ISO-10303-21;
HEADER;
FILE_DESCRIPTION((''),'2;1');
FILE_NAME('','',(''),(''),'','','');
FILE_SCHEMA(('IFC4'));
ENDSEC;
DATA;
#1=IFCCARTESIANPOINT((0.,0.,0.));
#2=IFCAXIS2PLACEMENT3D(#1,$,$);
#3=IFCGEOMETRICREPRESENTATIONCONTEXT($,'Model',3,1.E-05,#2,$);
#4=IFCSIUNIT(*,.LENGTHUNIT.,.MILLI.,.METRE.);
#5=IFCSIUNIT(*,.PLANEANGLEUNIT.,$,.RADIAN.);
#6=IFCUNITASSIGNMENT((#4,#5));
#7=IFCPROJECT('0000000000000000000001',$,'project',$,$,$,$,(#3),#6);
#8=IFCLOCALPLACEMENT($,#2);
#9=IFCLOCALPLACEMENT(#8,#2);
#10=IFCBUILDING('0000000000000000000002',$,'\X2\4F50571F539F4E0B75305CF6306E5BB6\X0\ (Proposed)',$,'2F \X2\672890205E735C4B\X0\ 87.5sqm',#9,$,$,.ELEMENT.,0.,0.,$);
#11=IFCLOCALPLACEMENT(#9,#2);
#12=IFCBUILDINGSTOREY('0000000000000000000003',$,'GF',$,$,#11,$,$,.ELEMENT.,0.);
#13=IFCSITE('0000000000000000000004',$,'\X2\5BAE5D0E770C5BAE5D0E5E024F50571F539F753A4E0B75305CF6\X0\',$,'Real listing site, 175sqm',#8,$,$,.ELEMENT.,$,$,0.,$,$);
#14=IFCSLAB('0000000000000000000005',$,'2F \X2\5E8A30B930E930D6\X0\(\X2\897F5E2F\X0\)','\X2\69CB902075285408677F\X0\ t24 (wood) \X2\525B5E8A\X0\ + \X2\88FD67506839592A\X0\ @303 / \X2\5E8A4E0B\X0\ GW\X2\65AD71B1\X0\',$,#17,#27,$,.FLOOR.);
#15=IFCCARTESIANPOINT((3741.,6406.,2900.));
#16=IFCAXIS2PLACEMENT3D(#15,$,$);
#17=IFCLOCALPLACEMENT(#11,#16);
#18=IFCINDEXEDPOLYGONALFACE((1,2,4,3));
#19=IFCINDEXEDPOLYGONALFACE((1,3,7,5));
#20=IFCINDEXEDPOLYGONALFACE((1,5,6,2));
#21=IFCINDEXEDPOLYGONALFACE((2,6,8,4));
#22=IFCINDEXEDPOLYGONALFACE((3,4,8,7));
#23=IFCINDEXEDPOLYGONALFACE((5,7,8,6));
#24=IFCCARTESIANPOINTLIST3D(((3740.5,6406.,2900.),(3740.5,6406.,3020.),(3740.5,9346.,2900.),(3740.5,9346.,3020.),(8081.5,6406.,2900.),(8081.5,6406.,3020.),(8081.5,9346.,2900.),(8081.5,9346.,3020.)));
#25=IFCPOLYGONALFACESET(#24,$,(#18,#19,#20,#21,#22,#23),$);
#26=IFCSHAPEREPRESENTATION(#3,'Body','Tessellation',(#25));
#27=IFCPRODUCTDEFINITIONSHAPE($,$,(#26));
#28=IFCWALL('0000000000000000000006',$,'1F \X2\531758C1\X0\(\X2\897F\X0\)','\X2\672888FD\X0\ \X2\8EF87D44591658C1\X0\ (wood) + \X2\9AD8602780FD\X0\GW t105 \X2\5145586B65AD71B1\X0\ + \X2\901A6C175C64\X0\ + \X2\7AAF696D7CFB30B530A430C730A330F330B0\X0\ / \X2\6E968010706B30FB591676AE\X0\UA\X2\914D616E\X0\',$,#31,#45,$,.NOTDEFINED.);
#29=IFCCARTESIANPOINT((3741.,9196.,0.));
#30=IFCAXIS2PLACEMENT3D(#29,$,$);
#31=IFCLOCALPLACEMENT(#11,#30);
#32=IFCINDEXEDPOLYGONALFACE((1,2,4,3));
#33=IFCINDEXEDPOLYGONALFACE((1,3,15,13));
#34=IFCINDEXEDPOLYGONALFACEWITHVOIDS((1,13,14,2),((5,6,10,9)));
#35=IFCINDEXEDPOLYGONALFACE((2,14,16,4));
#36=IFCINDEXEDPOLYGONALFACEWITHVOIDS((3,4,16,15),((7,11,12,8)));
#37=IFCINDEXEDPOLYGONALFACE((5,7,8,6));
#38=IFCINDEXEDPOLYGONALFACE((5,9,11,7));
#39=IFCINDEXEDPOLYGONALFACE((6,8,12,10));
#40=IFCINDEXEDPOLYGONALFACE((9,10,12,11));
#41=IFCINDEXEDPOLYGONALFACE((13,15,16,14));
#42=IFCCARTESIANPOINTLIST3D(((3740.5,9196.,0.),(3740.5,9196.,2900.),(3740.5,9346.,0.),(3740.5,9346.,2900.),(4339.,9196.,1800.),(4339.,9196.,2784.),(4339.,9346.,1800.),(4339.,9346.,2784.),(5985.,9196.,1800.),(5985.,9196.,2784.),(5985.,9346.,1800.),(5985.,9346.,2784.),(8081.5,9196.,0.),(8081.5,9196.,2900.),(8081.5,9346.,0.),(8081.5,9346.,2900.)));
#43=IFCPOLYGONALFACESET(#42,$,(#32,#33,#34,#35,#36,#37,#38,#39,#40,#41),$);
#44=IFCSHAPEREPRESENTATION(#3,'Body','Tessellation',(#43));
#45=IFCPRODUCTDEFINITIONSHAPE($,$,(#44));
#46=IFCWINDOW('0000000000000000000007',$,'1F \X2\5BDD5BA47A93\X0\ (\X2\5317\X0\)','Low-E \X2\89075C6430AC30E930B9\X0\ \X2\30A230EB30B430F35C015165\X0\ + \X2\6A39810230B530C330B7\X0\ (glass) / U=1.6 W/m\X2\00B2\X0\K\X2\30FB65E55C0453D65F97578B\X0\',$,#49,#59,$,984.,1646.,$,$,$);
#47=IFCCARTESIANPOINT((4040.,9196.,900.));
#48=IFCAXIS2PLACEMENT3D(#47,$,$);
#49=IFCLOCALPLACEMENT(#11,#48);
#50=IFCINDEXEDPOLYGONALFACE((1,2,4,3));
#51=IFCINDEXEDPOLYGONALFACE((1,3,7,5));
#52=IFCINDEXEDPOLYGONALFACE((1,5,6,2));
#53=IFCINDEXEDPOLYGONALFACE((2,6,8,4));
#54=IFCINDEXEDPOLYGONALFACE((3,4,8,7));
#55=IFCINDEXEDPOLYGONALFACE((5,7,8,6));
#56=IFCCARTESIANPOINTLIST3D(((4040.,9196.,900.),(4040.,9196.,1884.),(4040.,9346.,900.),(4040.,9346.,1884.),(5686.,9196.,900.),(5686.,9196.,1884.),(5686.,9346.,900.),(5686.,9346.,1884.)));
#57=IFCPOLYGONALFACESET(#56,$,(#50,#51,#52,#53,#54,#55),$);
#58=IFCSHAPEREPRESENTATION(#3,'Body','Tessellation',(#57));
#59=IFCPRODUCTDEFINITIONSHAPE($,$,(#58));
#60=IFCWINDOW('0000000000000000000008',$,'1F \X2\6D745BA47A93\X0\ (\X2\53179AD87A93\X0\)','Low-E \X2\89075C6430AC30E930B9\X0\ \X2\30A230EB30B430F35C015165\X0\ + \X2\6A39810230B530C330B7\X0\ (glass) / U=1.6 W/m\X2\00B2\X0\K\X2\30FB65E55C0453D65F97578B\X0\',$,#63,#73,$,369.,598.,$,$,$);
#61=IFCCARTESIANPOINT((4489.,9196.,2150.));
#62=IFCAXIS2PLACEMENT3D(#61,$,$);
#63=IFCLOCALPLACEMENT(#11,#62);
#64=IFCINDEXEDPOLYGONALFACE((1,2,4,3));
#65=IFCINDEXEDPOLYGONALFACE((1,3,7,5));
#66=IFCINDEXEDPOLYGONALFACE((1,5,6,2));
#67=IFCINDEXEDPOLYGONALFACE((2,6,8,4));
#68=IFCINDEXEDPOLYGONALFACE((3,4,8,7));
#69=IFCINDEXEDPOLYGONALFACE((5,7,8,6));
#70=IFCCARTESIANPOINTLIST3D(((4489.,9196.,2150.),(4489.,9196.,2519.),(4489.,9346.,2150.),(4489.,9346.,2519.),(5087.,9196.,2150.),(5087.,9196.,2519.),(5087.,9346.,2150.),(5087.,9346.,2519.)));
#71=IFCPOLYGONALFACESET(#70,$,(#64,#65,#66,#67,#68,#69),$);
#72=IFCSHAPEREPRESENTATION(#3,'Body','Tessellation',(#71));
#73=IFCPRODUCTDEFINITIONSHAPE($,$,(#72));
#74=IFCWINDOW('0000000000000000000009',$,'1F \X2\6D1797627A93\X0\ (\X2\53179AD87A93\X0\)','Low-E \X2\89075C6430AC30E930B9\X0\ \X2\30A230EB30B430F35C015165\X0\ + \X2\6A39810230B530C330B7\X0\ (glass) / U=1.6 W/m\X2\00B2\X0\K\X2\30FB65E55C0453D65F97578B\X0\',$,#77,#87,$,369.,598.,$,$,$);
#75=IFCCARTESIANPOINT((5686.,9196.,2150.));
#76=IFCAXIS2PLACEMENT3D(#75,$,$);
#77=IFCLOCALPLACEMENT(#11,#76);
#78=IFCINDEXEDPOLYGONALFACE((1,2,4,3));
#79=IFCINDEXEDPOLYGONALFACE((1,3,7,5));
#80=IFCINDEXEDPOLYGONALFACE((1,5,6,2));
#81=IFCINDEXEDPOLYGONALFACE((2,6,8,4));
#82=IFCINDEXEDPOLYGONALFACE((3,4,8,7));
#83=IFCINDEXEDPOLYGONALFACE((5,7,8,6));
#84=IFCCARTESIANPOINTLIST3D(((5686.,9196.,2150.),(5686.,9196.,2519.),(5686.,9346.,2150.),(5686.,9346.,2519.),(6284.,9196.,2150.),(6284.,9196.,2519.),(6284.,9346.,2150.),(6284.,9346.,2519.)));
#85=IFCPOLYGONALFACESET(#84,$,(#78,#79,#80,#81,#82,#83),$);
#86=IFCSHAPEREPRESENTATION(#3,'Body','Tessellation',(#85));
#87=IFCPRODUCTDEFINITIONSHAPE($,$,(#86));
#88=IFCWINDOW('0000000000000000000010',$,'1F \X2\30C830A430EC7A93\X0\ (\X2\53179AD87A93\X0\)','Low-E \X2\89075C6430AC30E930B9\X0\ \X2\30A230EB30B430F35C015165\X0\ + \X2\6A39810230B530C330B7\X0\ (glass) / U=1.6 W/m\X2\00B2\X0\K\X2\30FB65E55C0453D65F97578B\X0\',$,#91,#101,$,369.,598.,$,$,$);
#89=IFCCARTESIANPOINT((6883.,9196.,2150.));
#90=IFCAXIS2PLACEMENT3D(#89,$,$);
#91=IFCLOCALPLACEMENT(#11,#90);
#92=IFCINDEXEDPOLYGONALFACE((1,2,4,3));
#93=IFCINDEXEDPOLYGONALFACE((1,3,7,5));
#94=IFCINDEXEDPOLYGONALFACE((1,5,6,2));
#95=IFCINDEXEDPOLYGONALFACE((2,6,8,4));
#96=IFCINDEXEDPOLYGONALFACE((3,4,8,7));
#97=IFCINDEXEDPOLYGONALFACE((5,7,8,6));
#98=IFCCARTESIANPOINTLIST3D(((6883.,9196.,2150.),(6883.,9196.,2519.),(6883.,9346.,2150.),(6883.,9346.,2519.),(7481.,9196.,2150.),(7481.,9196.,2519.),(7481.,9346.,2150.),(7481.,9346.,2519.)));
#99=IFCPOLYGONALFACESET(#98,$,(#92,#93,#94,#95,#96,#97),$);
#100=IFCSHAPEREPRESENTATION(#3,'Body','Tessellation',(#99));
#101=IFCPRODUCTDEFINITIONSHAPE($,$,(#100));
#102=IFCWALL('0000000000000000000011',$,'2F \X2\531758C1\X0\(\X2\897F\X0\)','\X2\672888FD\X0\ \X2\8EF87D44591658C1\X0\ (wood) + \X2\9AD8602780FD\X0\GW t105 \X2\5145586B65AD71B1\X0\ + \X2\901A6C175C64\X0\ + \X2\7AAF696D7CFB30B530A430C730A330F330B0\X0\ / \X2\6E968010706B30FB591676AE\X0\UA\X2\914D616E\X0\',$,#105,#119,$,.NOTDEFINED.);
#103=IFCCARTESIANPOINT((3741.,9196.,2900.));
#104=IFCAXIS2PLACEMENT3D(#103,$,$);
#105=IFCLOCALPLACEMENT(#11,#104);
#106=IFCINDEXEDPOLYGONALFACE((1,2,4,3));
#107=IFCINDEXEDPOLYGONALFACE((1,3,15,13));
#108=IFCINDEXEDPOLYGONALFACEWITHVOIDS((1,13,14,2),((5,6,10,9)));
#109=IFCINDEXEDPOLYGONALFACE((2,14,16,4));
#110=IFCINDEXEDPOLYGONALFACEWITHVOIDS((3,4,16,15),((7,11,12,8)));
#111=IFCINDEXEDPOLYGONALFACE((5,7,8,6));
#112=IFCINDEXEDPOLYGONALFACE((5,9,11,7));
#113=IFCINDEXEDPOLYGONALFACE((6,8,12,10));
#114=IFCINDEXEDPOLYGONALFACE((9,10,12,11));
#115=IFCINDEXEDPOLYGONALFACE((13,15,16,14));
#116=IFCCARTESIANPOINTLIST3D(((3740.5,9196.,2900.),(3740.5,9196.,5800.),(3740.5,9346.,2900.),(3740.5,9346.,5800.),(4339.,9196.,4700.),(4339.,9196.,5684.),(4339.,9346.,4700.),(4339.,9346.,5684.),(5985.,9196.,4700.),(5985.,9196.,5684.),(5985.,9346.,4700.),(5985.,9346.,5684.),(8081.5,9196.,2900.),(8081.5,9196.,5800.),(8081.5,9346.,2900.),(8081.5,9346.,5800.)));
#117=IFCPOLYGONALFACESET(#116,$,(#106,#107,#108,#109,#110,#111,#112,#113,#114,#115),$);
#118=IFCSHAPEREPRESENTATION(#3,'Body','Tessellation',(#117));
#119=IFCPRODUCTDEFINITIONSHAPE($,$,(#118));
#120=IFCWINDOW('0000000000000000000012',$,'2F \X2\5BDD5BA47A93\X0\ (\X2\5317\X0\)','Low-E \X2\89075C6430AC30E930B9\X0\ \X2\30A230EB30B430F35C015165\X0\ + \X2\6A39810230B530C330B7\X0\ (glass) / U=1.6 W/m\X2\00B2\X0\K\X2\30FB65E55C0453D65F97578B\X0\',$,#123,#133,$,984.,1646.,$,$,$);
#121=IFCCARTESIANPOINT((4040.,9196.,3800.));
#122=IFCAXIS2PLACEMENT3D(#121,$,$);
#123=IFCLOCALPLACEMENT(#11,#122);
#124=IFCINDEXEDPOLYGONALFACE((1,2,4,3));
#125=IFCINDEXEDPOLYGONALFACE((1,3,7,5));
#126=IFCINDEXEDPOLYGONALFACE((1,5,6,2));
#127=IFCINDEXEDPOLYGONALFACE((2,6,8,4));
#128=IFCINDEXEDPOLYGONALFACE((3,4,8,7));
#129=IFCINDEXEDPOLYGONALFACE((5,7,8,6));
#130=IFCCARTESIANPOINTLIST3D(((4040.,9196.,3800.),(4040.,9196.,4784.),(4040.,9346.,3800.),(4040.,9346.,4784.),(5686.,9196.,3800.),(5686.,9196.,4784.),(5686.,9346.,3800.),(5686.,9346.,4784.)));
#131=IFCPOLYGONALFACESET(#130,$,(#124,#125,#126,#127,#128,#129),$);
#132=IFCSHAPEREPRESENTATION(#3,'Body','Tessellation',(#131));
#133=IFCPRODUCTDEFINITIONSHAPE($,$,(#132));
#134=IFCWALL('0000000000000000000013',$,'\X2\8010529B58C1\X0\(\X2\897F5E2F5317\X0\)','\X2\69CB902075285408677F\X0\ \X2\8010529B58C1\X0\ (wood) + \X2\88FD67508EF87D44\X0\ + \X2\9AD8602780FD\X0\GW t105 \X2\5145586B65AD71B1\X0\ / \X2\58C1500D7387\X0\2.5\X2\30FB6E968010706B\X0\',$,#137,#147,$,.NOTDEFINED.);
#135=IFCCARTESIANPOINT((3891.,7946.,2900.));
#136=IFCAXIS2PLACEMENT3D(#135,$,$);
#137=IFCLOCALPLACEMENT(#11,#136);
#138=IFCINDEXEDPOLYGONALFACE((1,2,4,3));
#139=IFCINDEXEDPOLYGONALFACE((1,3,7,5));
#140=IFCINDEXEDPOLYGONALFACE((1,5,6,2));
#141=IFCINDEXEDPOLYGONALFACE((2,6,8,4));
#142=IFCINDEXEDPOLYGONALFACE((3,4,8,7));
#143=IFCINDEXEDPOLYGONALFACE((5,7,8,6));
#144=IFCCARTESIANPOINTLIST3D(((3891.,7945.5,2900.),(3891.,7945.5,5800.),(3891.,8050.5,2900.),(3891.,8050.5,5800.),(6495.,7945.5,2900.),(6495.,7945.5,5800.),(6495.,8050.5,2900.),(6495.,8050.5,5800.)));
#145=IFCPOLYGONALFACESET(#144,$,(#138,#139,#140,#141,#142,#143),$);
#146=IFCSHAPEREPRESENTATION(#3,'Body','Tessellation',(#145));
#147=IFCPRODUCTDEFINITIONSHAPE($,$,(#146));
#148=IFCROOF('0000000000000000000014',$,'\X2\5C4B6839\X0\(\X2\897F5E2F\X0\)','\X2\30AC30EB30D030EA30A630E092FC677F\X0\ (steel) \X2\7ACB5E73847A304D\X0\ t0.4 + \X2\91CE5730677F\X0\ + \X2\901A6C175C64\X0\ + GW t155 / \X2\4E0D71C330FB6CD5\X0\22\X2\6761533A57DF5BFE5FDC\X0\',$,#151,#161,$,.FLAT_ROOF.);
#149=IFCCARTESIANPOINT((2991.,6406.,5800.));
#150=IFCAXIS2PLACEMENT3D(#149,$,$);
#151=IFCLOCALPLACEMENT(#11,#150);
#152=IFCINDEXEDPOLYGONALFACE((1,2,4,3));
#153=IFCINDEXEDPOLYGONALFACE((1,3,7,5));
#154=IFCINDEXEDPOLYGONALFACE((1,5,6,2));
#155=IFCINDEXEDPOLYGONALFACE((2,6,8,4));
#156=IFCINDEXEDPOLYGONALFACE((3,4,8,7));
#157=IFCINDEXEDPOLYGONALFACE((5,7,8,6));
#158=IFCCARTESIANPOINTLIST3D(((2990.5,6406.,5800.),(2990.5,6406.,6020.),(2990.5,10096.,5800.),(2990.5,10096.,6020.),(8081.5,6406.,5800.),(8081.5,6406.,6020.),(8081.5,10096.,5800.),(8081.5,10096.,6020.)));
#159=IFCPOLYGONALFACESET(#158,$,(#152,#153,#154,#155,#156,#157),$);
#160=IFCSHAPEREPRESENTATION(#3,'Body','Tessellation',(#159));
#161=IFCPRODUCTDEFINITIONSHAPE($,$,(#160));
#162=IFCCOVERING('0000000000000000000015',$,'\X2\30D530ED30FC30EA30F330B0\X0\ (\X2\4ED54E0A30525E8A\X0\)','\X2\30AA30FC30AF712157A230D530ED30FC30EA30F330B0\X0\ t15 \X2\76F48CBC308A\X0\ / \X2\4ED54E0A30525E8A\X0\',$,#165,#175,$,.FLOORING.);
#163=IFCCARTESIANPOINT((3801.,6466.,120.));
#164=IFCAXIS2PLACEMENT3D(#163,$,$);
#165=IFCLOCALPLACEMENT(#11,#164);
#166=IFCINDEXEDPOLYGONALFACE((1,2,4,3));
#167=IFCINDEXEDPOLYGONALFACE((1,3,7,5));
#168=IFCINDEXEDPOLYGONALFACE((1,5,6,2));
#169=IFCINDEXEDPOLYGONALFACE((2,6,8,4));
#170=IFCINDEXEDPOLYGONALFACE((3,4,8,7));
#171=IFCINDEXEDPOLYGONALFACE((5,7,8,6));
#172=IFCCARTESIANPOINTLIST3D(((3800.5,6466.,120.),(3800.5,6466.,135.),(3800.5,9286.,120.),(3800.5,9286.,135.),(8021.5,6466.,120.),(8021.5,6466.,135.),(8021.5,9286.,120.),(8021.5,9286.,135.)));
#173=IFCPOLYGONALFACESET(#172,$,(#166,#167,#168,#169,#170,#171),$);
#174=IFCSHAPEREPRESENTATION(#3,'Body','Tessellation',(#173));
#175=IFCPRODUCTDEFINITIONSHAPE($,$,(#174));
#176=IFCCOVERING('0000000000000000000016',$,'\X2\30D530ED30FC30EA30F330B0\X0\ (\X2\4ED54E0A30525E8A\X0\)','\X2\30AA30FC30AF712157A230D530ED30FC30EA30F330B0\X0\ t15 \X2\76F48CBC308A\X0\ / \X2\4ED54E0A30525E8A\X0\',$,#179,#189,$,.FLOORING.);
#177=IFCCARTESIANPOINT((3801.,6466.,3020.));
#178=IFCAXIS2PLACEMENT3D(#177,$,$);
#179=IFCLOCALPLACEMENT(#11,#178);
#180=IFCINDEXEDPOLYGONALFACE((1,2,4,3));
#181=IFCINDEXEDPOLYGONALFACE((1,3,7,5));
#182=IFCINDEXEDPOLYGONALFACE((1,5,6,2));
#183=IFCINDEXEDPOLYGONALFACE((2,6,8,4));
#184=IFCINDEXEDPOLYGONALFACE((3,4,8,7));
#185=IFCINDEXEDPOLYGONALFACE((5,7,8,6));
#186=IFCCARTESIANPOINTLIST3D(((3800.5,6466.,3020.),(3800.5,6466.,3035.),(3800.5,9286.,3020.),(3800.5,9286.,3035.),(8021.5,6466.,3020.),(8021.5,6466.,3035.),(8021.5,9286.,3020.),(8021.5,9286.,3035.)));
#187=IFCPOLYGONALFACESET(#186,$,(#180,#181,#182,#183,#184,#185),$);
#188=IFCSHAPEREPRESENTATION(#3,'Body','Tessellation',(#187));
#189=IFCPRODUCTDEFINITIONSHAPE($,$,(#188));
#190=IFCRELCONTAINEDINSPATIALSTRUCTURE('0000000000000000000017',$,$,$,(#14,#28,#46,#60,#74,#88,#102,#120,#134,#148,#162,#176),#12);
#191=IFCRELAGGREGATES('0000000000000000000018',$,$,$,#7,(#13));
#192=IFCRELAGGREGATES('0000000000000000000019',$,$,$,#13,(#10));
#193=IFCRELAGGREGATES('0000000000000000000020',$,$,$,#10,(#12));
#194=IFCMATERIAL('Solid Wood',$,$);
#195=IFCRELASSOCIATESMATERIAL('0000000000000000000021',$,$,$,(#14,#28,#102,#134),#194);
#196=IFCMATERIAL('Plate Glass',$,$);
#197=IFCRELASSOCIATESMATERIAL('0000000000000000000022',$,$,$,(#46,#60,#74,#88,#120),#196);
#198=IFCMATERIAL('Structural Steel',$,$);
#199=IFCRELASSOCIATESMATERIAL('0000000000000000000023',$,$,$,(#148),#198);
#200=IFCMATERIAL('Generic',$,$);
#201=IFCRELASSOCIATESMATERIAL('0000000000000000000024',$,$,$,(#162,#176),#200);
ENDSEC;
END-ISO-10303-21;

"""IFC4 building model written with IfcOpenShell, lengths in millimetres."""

from ifc_helpers import new_model, si_unit, frame, frame_2d, origin, place, context, project, spatial, rectangle, extrude, material, element, fill, save


model = new_model("IFC4")

# Units and contexts
model_context = context("Model", 3, precision=1e-05, world=origin())
ifc_project = project(units=[si_unit("LENGTHUNIT", "METRE", prefix="MILLI"), si_unit("PLANEANGLEUNIT", "RADIAN")], contexts=[model_context])

# Site, building, storey
site_placement = place(None, origin())
site = spatial("IfcSite", under=ifc_project, at=site_placement, Name="宮崎県宮崎市佐土原町下田島", ObjectType="Real listing site, 175sqm", CompositionType="ELEMENT", RefElevation=0.0)
building_placement = place(site_placement, origin())
building = spatial("IfcBuilding", under=site, at=building_placement, Name="佐土原下田島の家 (Proposed)", ObjectType="2F 木造平屋 87.5sqm", CompositionType="ELEMENT", ElevationOfRefHeight=0.0, ElevationOfTerrain=0.0)
storey_placement = place(building_placement, origin())
storey = spatial("IfcBuildingStorey", under=building, at=storey_placement, Name="GF", CompositionType="ELEMENT", Elevation=0.0)

# Slab
ifc_material_1 = material(Name="Solid Wood")
slab_1_placement = place(storey_placement, frame((3741.0, 6406.0, 2900.0)))
element("IfcSlab", 1, at=slab_1_placement, inside=storey, material=ifc_material_1, Name="2F 床スラブ(西帯)", Description="構造用合板 t24 (wood) 剛床 + 製材根太 @303 / 床下 GW断熱", PredefinedType="FLOOR", context=model_context, shape_type="SweptSolid", body=[
    extrude(rectangle(XDim=4341.0, YDim=2940.0, at=frame_2d((2170.0, 1470.0))), frame((3741.0, 6406.0, 2900.0)), (0.0, 0.0, 1.0), 120.0),
])

# Wall, openings, windows
wall_1_placement = place(storey_placement, frame((3741.0, 9196.0, 0.0)))
wall_1 = element("IfcWall", 2, at=wall_1_placement, inside=storey, material=ifc_material_1, Name="1F 北壁(西)", Description="木製 軸組外壁 (wood) + 高性能GW t105 充填断熱 + 通気層 + 窯業系サイディング / 準耐火・外皮UA配慮", PredefinedType="NOTDEFINED", context=model_context, shape_type="SweptSolid", body=[
    extrude(rectangle(XDim=4341.0, YDim=150.0, at=frame_2d((2170.0, 75.0))), frame((3741.0, 9196.0, 0.0)), (0.0, 0.0, 1.0), 2900.0),
])
opening_1_placement = place(storey_placement, frame((4040.0, 9196.0, 900.0)))
opening_1 = element("IfcOpeningElement", 3, at=opening_1_placement, cuts=wall_1, PredefinedType="NOTDEFINED", context=model_context, shape_type="SweptSolid", body=[
    extrude(rectangle(XDim=1646.0, YDim=150.0, at=frame_2d((823.0, 75.0))), frame((4040.0, 9196.0, 900.0)), (0.0, 0.0, 1.0), 984.0),
])
opening_2_placement = place(storey_placement, frame((4489.0, 9196.0, 2150.0)))
opening_2 = element("IfcOpeningElement", 4, at=opening_2_placement, cuts=wall_1, PredefinedType="NOTDEFINED", context=model_context, shape_type="SweptSolid", body=[
    extrude(rectangle(XDim=598.0, YDim=150.0, at=frame_2d((299.0, 75.0))), frame((4489.0, 9196.0, 2150.0)), (0.0, 0.0, 1.0), 369.0),
])
opening_3_placement = place(storey_placement, frame((5686.0, 9196.0, 2150.0)))
opening_3 = element("IfcOpeningElement", 5, at=opening_3_placement, cuts=wall_1, PredefinedType="NOTDEFINED", context=model_context, shape_type="SweptSolid", body=[
    extrude(rectangle(XDim=598.0, YDim=150.0, at=frame_2d((299.0, 75.0))), frame((5686.0, 9196.0, 2150.0)), (0.0, 0.0, 1.0), 369.0),
])
opening_4_placement = place(storey_placement, frame((6883.0, 9196.0, 2150.0)))
opening_4 = element("IfcOpeningElement", 6, at=opening_4_placement, cuts=wall_1, PredefinedType="NOTDEFINED", context=model_context, shape_type="SweptSolid", body=[
    extrude(rectangle(XDim=598.0, YDim=150.0, at=frame_2d((299.0, 75.0))), frame((6883.0, 9196.0, 2150.0)), (0.0, 0.0, 1.0), 369.0),
])
ifc_material_2 = material(Name="Plate Glass")
window_1_placement = place(storey_placement, frame((4040.0, 9196.0, 900.0)))
window_1 = element("IfcWindow", 7, at=window_1_placement, inside=storey, material=ifc_material_2, Name="1F 寝室窓 (北)", Description="Low-E 複層ガラス アルゴン封入 + 樹脂サッシ (glass) / U=1.6 W/m²K・日射取得型", OverallHeight=984.0, OverallWidth=1646.0, context=model_context, shape_type="SweptSolid", body=[
    extrude(rectangle(XDim=1646.0, YDim=150.0, at=frame_2d((823.0, 75.0))), frame((4040.0, 9196.0, 900.0)), (0.0, 0.0, 1.0), 984.0),
])
fill(opening_1, window_1)
window_2_placement = place(storey_placement, frame((4489.0, 9196.0, 2150.0)))
window_2 = element("IfcWindow", 8, at=window_2_placement, inside=storey, material=ifc_material_2, Name="1F 浴室窓 (北高窓)", Description="Low-E 複層ガラス アルゴン封入 + 樹脂サッシ (glass) / U=1.6 W/m²K・日射取得型", OverallHeight=369.0, OverallWidth=598.0, context=model_context, shape_type="SweptSolid", body=[
    extrude(rectangle(XDim=598.0, YDim=150.0, at=frame_2d((299.0, 75.0))), frame((4489.0, 9196.0, 2150.0)), (0.0, 0.0, 1.0), 369.0),
])
fill(opening_2, window_2)
window_3_placement = place(storey_placement, frame((5686.0, 9196.0, 2150.0)))
window_3 = element("IfcWindow", 9, at=window_3_placement, inside=storey, material=ifc_material_2, Name="1F 洗面窓 (北高窓)", Description="Low-E 複層ガラス アルゴン封入 + 樹脂サッシ (glass) / U=1.6 W/m²K・日射取得型", OverallHeight=369.0, OverallWidth=598.0, context=model_context, shape_type="SweptSolid", body=[
    extrude(rectangle(XDim=598.0, YDim=150.0, at=frame_2d((299.0, 75.0))), frame((5686.0, 9196.0, 2150.0)), (0.0, 0.0, 1.0), 369.0),
])
fill(opening_3, window_3)
window_4_placement = place(storey_placement, frame((6883.0, 9196.0, 2150.0)))
window_4 = element("IfcWindow", 10, at=window_4_placement, inside=storey, material=ifc_material_2, Name="1F トイレ窓 (北高窓)", Description="Low-E 複層ガラス アルゴン封入 + 樹脂サッシ (glass) / U=1.6 W/m²K・日射取得型", OverallHeight=369.0, OverallWidth=598.0, context=model_context, shape_type="SweptSolid", body=[
    extrude(rectangle(XDim=598.0, YDim=150.0, at=frame_2d((299.0, 75.0))), frame((6883.0, 9196.0, 2150.0)), (0.0, 0.0, 1.0), 369.0),
])
fill(opening_4, window_4)

# Wall, opening, window
wall_2_placement = place(storey_placement, frame((3741.0, 9196.0, 2900.0)))
wall_2 = element("IfcWall", 11, at=wall_2_placement, inside=storey, material=ifc_material_1, Name="2F 北壁(西)", Description="木製 軸組外壁 (wood) + 高性能GW t105 充填断熱 + 通気層 + 窯業系サイディング / 準耐火・外皮UA配慮", PredefinedType="NOTDEFINED", context=model_context, shape_type="SweptSolid", body=[
    extrude(rectangle(XDim=4341.0, YDim=150.0, at=frame_2d((2170.0, 75.0))), frame((3741.0, 9196.0, 2900.0)), (0.0, 0.0, 1.0), 2900.0),
])
opening_5_placement = place(storey_placement, frame((4040.0, 9196.0, 3800.0)))
opening_5 = element("IfcOpeningElement", 12, at=opening_5_placement, cuts=wall_2, PredefinedType="NOTDEFINED", context=model_context, shape_type="SweptSolid", body=[
    extrude(rectangle(XDim=1646.0, YDim=150.0, at=frame_2d((823.0, 75.0))), frame((4040.0, 9196.0, 3800.0)), (0.0, 0.0, 1.0), 984.0),
])
window_5_placement = place(storey_placement, frame((4040.0, 9196.0, 3800.0)))
window_5 = element("IfcWindow", 13, at=window_5_placement, inside=storey, material=ifc_material_2, Name="2F 寝室窓 (北)", Description="Low-E 複層ガラス アルゴン封入 + 樹脂サッシ (glass) / U=1.6 W/m²K・日射取得型", OverallHeight=984.0, OverallWidth=1646.0, context=model_context, shape_type="SweptSolid", body=[
    extrude(rectangle(XDim=1646.0, YDim=150.0, at=frame_2d((823.0, 75.0))), frame((4040.0, 9196.0, 3800.0)), (0.0, 0.0, 1.0), 984.0),
])
fill(opening_5, window_5)

# Wall
wall_3_placement = place(storey_placement, frame((3891.0, 7946.0, 2900.0)))
element("IfcWall", 14, at=wall_3_placement, inside=storey, material=ifc_material_1, Name="耐力壁(西帯北)", Description="構造用合板 耐力壁 (wood) + 製材軸組 + 高性能GW t105 充填断熱 / 壁倍率2.5・準耐火", PredefinedType="NOTDEFINED", context=model_context, shape_type="SweptSolid", body=[
    extrude(rectangle(XDim=2604.0, YDim=105.0, at=frame_2d((1302.0, 52.0))), frame((3891.0, 7946.0, 2900.0)), (0.0, 0.0, 1.0), 2900.0),
])

# Roof
ifc_material_3 = material(Name="Structural Steel")
for number, where, name in (
    (15, (2991.0, 6406.0, 5800.0), "屋根(西帯)"),
):
    element("IfcRoof", number, at=place(storey_placement, frame(where)), inside=storey, material=ifc_material_3, Name=name, Description="ガルバリウム鋼板 (steel) 立平葺き t0.4 + 野地板 + 通気層 + GW t155 / 不燃・法22条区域対応", PredefinedType="FLAT_ROOF", context=model_context, shape_type="SweptSolid", body=[
        extrude(rectangle(XDim=5091.0, YDim=3690.0, at=frame_2d((2545.0, 1845.0))), frame((2991.0, 6406.0, 5800.0)), (0.0, 0.0, 1.0), 220.0),
    ])

# Coverings
ifc_material_4 = material(Name="Generic")
covering_1_placement = place(storey_placement, frame((3801.0, 6466.0, 120.0)))
element("IfcCovering", 16, at=covering_1_placement, inside=storey, material=ifc_material_4, Name="フローリング (仕上げ床)", Description="オーク無垢フローリング t15 直貼り / 仕上げ床", PredefinedType="FLOORING", context=model_context, shape_type="SweptSolid", body=[
    extrude(rectangle(XDim=4221.0, YDim=2820.0, at=frame_2d((2110.0, 1410.0))), frame((3801.0, 6466.0, 120.0)), (0.0, 0.0, 1.0), 15.0),
])
covering_2_placement = place(storey_placement, frame((3801.0, 6466.0, 3020.0)))
element("IfcCovering", 17, at=covering_2_placement, inside=storey, material=ifc_material_4, Name="フローリング (仕上げ床)", Description="オーク無垢フローリング t15 直貼り / 仕上げ床", PredefinedType="FLOORING", context=model_context, shape_type="SweptSolid", body=[
    extrude(rectangle(XDim=4221.0, YDim=2820.0, at=frame_2d((2110.0, 1410.0))), frame((3801.0, 6466.0, 3020.0)), (0.0, 0.0, 1.0), 15.0),
])

save(model, "model.ifc")
